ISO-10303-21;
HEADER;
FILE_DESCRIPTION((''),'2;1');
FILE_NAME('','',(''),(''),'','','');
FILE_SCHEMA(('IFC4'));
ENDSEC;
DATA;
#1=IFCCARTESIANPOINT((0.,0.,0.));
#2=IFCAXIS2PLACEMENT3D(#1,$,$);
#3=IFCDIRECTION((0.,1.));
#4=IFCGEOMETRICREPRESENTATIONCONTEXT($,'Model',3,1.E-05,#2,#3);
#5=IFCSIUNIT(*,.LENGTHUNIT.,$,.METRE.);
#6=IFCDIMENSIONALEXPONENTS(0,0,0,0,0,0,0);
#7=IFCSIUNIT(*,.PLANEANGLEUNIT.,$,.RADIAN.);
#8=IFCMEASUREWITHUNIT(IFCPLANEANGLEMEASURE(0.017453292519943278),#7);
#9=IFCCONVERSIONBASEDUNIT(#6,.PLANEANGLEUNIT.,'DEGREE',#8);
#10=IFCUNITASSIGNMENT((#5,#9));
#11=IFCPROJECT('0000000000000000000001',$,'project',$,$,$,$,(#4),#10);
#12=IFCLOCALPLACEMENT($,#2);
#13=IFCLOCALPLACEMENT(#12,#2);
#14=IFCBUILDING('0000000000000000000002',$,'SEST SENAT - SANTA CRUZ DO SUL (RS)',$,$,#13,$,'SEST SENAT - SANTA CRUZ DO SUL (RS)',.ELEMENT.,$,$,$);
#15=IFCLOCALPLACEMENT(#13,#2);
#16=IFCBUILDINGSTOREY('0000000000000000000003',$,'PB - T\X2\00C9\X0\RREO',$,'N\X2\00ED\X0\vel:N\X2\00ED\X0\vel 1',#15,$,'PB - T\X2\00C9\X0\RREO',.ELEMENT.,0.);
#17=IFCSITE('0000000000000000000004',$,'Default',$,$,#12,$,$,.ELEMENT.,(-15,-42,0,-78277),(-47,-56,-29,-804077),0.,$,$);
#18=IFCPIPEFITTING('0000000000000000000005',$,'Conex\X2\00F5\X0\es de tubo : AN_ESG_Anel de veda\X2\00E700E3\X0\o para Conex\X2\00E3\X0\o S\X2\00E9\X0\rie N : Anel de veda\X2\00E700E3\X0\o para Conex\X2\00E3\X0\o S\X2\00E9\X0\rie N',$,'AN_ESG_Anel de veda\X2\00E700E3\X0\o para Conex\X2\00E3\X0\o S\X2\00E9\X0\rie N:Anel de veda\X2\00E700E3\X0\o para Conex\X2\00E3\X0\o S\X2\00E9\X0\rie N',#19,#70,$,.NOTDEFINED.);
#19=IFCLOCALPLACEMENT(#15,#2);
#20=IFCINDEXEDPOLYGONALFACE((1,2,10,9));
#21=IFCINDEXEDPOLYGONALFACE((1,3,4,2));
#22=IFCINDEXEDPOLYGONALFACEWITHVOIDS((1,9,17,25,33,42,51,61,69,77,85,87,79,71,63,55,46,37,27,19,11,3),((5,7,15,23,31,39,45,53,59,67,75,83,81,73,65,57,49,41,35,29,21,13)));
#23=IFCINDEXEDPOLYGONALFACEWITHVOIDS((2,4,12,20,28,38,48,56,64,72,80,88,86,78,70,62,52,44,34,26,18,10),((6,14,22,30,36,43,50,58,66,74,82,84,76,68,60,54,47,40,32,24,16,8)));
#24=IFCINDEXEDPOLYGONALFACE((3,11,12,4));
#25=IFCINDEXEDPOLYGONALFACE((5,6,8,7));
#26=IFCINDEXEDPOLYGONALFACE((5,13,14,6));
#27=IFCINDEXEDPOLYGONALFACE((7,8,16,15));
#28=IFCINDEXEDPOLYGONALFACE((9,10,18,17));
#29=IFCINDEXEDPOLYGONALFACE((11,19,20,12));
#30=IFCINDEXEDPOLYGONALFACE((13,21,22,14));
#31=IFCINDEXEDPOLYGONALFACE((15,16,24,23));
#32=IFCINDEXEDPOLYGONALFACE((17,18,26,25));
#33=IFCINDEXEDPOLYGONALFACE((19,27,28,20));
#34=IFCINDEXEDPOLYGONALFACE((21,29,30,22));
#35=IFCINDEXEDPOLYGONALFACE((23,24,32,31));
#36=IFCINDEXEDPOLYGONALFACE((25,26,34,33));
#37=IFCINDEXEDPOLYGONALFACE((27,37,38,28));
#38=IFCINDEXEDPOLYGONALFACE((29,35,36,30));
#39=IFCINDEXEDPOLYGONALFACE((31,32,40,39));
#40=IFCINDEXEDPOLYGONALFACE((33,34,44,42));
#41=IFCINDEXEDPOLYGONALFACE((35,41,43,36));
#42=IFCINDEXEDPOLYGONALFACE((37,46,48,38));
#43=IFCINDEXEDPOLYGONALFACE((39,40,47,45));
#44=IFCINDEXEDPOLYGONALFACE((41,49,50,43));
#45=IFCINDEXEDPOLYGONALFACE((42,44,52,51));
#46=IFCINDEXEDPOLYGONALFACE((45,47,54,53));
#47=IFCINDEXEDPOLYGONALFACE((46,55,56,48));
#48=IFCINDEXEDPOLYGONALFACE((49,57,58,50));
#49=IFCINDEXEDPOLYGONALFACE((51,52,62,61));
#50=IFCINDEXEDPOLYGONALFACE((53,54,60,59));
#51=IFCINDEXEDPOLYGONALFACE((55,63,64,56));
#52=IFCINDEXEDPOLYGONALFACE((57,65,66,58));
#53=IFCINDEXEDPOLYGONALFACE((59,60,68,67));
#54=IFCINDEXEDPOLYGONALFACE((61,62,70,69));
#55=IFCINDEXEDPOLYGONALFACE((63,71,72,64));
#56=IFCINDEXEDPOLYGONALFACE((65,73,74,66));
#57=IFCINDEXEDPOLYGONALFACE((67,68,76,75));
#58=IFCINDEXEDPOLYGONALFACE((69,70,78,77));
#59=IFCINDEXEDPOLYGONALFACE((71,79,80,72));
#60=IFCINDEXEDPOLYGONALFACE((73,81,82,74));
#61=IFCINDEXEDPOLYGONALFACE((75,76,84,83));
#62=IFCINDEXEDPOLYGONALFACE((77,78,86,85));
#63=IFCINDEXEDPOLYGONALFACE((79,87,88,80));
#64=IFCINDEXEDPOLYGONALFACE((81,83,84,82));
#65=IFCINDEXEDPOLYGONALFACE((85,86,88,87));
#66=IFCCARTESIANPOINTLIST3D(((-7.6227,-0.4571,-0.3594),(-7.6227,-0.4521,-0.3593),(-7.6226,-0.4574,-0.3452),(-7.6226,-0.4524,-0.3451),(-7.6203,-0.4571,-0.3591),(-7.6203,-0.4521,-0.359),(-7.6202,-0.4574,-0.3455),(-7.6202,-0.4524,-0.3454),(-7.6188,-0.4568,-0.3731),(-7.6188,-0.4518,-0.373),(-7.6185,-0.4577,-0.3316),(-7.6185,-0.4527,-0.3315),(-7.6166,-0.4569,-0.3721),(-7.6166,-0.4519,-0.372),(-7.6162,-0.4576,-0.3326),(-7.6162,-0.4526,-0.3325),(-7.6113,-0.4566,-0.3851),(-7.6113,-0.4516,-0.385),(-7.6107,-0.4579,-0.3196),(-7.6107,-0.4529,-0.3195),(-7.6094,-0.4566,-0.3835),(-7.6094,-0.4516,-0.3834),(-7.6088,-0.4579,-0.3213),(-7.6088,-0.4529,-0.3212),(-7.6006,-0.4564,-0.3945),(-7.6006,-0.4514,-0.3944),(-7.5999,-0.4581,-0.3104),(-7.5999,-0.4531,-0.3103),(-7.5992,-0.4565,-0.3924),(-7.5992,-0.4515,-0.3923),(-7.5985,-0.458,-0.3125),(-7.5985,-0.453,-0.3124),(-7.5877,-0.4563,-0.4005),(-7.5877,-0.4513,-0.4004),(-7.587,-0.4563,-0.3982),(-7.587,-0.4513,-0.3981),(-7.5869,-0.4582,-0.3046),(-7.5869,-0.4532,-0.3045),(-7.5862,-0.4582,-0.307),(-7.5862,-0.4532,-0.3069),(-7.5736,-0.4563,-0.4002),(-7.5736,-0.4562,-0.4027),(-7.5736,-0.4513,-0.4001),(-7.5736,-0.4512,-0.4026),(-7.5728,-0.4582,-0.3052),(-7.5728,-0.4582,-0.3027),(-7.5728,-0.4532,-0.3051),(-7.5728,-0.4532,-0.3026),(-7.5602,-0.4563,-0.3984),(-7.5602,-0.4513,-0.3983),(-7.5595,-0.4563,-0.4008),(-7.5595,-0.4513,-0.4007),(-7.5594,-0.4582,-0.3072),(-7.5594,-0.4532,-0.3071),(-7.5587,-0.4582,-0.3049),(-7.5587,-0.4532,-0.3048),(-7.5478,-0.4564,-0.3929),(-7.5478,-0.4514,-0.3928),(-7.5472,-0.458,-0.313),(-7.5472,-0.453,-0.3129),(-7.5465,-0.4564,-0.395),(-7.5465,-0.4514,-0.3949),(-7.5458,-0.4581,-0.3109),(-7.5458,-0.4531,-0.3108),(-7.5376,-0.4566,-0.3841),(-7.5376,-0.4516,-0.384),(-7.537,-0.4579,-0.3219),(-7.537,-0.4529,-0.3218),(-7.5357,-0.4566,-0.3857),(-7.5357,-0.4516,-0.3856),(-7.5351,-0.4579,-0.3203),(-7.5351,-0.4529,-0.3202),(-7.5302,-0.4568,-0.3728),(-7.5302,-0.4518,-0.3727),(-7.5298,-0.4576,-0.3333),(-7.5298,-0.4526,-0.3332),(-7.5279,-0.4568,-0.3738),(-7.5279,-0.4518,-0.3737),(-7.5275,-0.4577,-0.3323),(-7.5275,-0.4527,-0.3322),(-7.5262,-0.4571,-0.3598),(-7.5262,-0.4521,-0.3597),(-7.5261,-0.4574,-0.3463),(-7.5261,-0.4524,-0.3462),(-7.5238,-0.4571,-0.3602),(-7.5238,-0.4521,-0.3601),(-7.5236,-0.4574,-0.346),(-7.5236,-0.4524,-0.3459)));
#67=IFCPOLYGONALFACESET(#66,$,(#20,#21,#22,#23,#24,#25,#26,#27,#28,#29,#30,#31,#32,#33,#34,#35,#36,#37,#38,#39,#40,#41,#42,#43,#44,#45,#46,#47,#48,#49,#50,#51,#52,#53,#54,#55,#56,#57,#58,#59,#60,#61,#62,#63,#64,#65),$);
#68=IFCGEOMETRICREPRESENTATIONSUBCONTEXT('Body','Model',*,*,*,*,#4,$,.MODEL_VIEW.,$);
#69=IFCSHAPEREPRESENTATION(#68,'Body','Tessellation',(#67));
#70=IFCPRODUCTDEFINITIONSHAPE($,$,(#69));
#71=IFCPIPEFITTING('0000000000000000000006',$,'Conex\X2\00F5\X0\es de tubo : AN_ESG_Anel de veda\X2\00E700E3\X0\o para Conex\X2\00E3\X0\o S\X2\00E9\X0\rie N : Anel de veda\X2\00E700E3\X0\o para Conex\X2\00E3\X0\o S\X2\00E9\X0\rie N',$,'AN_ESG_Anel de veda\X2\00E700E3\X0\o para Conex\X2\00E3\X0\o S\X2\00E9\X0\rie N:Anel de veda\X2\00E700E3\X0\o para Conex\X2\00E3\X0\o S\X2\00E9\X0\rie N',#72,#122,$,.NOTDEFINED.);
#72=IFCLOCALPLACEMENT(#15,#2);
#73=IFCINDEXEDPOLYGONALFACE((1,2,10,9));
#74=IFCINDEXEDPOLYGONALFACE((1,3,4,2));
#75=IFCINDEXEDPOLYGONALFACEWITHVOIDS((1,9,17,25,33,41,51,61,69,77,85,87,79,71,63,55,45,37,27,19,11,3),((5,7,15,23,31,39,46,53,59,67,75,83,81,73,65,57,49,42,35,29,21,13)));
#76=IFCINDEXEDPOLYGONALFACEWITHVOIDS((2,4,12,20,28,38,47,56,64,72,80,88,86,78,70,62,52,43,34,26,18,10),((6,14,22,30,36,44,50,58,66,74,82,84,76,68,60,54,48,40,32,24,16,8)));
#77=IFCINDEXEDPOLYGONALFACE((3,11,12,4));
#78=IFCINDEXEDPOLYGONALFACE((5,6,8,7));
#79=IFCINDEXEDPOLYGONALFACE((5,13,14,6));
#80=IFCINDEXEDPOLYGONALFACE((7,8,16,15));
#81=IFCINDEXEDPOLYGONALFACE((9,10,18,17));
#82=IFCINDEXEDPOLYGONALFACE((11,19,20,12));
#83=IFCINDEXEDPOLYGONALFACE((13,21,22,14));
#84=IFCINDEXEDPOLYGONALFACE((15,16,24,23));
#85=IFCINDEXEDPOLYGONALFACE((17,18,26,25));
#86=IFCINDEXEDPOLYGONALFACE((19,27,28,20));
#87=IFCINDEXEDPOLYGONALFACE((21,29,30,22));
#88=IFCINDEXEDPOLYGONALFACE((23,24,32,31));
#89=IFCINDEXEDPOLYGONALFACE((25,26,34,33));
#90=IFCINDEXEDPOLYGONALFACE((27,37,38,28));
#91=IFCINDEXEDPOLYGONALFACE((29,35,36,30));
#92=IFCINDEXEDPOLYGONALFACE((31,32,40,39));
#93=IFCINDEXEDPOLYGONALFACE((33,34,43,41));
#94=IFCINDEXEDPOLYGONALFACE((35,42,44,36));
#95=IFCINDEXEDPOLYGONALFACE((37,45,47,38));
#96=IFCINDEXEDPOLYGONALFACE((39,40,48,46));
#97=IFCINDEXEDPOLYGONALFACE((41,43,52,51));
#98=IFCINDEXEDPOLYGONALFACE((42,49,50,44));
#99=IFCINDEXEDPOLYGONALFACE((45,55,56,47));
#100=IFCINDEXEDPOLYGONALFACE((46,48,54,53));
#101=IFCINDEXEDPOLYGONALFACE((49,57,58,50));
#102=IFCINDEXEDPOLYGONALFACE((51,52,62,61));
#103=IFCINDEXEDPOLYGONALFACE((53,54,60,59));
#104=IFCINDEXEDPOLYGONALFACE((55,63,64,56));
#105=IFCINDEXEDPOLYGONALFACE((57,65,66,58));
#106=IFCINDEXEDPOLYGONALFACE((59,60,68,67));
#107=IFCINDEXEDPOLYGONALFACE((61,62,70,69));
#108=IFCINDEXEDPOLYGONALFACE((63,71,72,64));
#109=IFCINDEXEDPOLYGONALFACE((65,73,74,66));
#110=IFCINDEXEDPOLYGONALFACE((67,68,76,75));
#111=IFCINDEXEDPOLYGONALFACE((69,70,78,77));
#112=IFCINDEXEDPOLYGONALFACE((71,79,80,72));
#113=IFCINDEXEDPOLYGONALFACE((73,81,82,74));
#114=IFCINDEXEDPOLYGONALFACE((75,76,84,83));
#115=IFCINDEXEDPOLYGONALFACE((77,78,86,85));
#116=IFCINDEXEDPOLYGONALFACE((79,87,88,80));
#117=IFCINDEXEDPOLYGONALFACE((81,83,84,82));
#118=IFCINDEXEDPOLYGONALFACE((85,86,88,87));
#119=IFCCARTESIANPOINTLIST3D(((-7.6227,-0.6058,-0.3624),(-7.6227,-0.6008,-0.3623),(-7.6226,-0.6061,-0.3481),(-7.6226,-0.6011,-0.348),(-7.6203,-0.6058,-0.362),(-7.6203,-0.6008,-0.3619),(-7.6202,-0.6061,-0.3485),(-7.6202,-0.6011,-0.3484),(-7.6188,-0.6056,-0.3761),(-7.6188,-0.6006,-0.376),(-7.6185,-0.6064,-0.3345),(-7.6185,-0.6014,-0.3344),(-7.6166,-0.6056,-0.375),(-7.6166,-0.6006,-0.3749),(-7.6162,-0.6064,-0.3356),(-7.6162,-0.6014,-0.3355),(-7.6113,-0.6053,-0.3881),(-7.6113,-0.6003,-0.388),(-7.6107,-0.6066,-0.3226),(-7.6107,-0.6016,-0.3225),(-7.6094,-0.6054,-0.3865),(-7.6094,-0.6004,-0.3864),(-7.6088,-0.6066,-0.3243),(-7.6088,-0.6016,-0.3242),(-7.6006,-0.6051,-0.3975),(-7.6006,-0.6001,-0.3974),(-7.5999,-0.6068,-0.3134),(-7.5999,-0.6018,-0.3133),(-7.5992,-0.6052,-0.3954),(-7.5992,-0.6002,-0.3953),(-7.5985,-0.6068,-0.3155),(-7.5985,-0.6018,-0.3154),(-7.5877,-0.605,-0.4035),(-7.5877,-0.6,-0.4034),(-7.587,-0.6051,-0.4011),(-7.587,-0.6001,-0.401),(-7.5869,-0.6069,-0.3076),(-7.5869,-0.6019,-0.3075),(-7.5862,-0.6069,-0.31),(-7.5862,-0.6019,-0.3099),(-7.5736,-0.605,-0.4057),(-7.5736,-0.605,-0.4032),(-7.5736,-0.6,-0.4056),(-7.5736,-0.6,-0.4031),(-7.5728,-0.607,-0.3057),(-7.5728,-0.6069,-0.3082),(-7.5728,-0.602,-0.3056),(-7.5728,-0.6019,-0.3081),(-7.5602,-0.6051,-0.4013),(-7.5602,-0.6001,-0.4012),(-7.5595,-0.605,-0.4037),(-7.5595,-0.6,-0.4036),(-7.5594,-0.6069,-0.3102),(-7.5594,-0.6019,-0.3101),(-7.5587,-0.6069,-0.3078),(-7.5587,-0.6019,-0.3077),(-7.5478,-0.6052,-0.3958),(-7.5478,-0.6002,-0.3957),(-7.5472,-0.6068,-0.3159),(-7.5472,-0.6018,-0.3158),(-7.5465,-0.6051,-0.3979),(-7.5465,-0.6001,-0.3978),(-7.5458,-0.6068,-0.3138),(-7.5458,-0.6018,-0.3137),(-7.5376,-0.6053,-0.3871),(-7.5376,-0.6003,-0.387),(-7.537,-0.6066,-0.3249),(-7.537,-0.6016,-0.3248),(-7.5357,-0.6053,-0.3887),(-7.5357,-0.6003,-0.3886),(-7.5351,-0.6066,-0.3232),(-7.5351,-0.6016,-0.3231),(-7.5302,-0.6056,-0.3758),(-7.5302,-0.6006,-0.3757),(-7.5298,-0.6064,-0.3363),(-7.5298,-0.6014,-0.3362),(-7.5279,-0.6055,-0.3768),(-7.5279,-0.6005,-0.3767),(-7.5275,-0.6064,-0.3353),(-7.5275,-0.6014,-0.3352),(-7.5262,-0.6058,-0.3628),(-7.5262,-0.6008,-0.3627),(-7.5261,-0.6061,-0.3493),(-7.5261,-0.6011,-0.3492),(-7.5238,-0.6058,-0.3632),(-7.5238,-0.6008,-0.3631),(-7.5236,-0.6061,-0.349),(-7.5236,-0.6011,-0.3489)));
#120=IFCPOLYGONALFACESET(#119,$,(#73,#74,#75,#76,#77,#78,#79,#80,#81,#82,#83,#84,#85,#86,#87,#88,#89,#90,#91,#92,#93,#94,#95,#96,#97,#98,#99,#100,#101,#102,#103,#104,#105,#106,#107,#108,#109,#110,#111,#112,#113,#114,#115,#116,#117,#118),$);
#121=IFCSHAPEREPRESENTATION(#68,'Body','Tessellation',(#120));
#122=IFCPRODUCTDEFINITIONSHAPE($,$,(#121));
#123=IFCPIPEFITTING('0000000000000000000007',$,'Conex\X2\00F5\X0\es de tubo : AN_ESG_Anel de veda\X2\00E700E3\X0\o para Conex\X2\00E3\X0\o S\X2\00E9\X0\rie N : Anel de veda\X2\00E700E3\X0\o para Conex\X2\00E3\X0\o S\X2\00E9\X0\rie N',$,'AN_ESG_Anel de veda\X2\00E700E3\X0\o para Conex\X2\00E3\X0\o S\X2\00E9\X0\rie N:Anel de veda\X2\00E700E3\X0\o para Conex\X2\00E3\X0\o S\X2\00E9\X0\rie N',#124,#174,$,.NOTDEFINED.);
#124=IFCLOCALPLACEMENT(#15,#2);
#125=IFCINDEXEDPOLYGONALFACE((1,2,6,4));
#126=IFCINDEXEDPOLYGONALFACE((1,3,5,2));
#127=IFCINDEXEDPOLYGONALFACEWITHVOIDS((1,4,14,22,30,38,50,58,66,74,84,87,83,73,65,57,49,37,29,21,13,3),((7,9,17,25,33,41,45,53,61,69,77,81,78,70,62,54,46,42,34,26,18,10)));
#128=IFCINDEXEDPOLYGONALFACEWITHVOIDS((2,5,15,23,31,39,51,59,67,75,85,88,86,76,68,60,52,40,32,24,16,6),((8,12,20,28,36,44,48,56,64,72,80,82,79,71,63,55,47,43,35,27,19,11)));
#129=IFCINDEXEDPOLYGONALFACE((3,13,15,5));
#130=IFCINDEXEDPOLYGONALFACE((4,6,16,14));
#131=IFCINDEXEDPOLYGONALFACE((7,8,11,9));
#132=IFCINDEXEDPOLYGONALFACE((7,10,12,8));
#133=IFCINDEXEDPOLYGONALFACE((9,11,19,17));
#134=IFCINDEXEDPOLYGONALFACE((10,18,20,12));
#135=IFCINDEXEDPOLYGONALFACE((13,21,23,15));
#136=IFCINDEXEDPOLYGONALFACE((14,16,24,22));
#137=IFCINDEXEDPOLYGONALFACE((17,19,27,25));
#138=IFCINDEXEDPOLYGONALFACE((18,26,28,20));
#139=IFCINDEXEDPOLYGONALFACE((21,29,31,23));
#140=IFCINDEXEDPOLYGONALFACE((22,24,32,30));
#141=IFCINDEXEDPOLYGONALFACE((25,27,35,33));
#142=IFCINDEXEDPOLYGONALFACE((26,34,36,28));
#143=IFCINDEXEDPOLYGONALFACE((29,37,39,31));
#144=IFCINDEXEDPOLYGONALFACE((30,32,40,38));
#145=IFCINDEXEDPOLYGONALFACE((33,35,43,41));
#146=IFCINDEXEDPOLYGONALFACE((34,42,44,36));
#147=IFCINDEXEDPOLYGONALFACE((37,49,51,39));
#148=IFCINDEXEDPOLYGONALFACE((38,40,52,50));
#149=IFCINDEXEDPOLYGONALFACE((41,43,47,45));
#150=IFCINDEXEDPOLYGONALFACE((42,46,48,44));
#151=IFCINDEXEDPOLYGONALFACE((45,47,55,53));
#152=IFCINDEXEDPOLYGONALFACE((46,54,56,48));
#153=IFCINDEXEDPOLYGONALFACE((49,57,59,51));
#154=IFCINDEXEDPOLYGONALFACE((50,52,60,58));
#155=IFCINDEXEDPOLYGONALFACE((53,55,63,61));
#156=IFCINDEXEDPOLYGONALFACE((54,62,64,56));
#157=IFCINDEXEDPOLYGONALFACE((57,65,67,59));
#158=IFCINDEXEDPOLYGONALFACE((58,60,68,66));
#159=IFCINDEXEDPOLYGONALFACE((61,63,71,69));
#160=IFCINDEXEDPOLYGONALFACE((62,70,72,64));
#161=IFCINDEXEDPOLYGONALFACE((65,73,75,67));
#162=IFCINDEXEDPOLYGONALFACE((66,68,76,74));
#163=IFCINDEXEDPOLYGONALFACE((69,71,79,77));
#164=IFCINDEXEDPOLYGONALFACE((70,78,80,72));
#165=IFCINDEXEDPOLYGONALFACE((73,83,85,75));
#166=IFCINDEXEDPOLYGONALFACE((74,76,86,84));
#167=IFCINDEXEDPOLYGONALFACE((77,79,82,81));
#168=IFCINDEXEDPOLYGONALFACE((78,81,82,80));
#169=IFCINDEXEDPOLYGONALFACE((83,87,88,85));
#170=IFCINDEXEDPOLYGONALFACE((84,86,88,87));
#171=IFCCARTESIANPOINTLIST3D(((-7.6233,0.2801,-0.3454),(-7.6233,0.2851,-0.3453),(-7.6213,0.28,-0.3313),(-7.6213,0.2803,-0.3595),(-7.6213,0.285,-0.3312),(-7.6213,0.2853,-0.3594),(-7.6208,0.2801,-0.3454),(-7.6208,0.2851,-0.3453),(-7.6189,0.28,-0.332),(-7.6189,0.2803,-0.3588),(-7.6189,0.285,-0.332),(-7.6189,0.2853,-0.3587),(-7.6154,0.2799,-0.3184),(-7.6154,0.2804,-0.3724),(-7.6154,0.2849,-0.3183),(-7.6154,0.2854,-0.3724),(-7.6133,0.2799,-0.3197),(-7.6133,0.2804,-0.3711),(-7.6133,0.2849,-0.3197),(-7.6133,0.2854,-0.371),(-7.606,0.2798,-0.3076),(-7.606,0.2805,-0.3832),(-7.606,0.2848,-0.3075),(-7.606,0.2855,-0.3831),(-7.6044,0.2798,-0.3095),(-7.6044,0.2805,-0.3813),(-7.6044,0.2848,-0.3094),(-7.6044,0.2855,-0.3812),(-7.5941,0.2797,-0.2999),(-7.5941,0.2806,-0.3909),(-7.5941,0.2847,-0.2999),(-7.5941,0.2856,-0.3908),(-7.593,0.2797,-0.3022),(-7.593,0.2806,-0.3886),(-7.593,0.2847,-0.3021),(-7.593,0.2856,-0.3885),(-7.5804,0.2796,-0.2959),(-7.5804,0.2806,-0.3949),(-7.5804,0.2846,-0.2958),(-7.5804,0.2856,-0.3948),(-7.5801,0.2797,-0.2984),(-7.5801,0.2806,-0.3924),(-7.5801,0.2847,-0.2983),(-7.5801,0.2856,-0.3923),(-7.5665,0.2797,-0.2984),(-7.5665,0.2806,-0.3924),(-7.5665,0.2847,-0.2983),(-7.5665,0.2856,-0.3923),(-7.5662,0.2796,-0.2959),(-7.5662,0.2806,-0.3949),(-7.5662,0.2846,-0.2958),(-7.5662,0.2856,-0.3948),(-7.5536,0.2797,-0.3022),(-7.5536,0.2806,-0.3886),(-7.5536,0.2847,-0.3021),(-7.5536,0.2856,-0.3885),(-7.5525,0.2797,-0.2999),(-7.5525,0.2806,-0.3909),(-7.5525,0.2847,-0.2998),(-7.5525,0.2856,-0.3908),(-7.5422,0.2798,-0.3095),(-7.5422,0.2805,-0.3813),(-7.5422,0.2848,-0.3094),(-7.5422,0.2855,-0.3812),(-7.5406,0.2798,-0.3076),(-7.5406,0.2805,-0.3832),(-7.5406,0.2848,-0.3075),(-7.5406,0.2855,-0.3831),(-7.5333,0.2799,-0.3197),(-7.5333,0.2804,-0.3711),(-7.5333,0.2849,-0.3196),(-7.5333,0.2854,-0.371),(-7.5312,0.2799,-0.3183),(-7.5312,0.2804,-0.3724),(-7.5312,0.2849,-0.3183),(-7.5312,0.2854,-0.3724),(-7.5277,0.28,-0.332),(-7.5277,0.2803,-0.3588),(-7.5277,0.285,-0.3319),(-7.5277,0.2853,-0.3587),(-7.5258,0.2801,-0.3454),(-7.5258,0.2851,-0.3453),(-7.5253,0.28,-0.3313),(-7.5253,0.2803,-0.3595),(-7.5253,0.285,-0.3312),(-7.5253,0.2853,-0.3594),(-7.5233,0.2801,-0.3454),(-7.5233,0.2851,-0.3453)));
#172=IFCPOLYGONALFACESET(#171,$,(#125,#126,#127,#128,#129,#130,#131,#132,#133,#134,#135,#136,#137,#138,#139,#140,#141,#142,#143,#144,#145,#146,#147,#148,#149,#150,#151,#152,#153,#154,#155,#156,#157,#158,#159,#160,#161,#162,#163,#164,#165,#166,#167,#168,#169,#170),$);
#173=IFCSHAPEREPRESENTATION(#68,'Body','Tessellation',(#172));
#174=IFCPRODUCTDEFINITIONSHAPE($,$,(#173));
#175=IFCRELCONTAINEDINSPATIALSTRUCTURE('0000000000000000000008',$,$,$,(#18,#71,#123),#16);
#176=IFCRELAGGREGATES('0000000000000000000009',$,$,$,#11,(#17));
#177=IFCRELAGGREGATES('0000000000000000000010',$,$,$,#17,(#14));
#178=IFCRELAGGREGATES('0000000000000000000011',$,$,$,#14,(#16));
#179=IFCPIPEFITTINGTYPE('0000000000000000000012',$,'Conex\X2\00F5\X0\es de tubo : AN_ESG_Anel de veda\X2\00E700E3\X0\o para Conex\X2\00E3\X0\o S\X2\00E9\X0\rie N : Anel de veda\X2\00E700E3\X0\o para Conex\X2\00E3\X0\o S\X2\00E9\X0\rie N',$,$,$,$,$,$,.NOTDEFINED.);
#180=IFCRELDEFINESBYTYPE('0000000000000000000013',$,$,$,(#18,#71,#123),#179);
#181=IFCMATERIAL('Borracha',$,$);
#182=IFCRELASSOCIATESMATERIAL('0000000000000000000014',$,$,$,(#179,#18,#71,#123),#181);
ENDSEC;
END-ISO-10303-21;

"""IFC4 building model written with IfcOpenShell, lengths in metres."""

from ifc_helpers import new_model, entity, si_unit, converted_unit, direction, frame, origin, place, context, subcontext, project, spatial, arc, indexed_curve, outline, extrude, source, transform, mapped, material, type_object, type_shapes, element, save


model = new_model("IFC4")

# Units and contexts
model_context = context("Model", 3, precision=1e-05, world=origin(), true_north=direction((0.0, 1.0)))
body_context = subcontext(model_context, "Body", "Model", "MODEL_VIEW")
ifc_project = project(units=[si_unit("LENGTHUNIT", "METRE"), converted_unit("PLANEANGLEUNIT", "DEGREE", entity("IfcPlaneAngleMeasure", 0.017453292519943278), si_unit("PLANEANGLEUNIT", "RADIAN"), dimensions=[0, 0, 0, 0, 0, 0, 0])], contexts=[model_context])

# Site, building, storey
site_placement = place(None, origin())
site = spatial("IfcSite", under=ifc_project, at=site_placement, Name="Default", CompositionType="ELEMENT", RefLatitude=(-15, -42, 0, -78277), RefLongitude=(-47, -56, -29, -804077), RefElevation=0.0)
building_placement = place(site_placement, origin())
building = spatial("IfcBuilding", under=site, at=building_placement, Name="SEST SENAT - SANTA CRUZ DO SUL (RS)", LongName="SEST SENAT - SANTA CRUZ DO SUL (RS)", CompositionType="ELEMENT")
storey_placement = place(building_placement, origin())
storey = spatial("IfcBuildingStorey", under=building, at=storey_placement, Name="PB - TÉRREO", ObjectType="Nível:Nível 1", LongName="PB - TÉRREO", CompositionType="ELEMENT", Elevation=0.0)

# Pipe fittings
ifc_material_1 = material(Name="Borracha")
pipe_fitting_type_1 = type_object("IfcPipeFittingType", Name="Conexões de tubo : AN_ESG_Anel de vedação para Conexão Série N : Anel de vedação para Conexão Série N", PredefinedType="NOTDEFINED", material=ifc_material_1)
shared_shape_1 = source(origin(), body_context, "Body", "SweptSolid", [
    extrude(outline(indexed_curve([(-0.05, 0.0), (0.0, -0.05), (0.05, 0.0), (0.0, 0.05)], segments=[arc(1, 2, 3), arc(3, 4, 1)], self_intersect=False), holes=[indexed_curve([(-0.0475, 0.0), (0.0, 0.0475), (0.0475, 0.0), (0.0, -0.0475)], segments=[arc(1, 2, 3), arc(3, 4, 1)], self_intersect=False)]), frame((0.0, 0.0, -0.005)), (0.0, 0.0, 1.0), 0.005),
])
type_shapes(pipe_fitting_type_1, [shared_shape_1])
for number, where, z_axis, x_axis, name in (
    (1, (-7.5732, -0.4572, -0.3527), (-0.000014, -0.9998, -0.019976), (-0.008302, 0.019975, -0.999766), "Conexões de tubo : AN_ESG_Anel de vedação para Conexão Série N : Anel de vedação para Conexão Série N"),
    (2, (-7.5732, -0.601, -0.3556), (0.000014, 0.9998, 0.019976), (-0.008302, 0.019975, -0.999766), "Conexões de tubo : AN_ESG_Anel de vedação para Conexão Série N : Anel de vedação para Conexão Série N"),
    (3, (-7.5733, 0.2801, -0.3454), (0.00001, -0.99995, -0.01), (1.0, 0.000009, 0.000058), "Conexões de tubo : AN_ESG_Anel de vedação para Conexão Série N : Anel de vedação para Conexão Série N"),
):
    element("IfcPipeFitting", number, at=place(storey_placement, frame(where, z_axis=z_axis, x_axis=x_axis)), inside=storey, type_object=pipe_fitting_type_1, material=ifc_material_1, Name=name, ObjectType="AN_ESG_Anel de vedação para Conexão Série N:Anel de vedação para Conexão Série N", PredefinedType="NOTDEFINED", context=body_context, shape_type="MappedRepresentation", body=[
        mapped(shared_shape_1, transform((0.0, 0.0, 0.0), scale=1.0)),
    ])

save(model, "model.ifc")
